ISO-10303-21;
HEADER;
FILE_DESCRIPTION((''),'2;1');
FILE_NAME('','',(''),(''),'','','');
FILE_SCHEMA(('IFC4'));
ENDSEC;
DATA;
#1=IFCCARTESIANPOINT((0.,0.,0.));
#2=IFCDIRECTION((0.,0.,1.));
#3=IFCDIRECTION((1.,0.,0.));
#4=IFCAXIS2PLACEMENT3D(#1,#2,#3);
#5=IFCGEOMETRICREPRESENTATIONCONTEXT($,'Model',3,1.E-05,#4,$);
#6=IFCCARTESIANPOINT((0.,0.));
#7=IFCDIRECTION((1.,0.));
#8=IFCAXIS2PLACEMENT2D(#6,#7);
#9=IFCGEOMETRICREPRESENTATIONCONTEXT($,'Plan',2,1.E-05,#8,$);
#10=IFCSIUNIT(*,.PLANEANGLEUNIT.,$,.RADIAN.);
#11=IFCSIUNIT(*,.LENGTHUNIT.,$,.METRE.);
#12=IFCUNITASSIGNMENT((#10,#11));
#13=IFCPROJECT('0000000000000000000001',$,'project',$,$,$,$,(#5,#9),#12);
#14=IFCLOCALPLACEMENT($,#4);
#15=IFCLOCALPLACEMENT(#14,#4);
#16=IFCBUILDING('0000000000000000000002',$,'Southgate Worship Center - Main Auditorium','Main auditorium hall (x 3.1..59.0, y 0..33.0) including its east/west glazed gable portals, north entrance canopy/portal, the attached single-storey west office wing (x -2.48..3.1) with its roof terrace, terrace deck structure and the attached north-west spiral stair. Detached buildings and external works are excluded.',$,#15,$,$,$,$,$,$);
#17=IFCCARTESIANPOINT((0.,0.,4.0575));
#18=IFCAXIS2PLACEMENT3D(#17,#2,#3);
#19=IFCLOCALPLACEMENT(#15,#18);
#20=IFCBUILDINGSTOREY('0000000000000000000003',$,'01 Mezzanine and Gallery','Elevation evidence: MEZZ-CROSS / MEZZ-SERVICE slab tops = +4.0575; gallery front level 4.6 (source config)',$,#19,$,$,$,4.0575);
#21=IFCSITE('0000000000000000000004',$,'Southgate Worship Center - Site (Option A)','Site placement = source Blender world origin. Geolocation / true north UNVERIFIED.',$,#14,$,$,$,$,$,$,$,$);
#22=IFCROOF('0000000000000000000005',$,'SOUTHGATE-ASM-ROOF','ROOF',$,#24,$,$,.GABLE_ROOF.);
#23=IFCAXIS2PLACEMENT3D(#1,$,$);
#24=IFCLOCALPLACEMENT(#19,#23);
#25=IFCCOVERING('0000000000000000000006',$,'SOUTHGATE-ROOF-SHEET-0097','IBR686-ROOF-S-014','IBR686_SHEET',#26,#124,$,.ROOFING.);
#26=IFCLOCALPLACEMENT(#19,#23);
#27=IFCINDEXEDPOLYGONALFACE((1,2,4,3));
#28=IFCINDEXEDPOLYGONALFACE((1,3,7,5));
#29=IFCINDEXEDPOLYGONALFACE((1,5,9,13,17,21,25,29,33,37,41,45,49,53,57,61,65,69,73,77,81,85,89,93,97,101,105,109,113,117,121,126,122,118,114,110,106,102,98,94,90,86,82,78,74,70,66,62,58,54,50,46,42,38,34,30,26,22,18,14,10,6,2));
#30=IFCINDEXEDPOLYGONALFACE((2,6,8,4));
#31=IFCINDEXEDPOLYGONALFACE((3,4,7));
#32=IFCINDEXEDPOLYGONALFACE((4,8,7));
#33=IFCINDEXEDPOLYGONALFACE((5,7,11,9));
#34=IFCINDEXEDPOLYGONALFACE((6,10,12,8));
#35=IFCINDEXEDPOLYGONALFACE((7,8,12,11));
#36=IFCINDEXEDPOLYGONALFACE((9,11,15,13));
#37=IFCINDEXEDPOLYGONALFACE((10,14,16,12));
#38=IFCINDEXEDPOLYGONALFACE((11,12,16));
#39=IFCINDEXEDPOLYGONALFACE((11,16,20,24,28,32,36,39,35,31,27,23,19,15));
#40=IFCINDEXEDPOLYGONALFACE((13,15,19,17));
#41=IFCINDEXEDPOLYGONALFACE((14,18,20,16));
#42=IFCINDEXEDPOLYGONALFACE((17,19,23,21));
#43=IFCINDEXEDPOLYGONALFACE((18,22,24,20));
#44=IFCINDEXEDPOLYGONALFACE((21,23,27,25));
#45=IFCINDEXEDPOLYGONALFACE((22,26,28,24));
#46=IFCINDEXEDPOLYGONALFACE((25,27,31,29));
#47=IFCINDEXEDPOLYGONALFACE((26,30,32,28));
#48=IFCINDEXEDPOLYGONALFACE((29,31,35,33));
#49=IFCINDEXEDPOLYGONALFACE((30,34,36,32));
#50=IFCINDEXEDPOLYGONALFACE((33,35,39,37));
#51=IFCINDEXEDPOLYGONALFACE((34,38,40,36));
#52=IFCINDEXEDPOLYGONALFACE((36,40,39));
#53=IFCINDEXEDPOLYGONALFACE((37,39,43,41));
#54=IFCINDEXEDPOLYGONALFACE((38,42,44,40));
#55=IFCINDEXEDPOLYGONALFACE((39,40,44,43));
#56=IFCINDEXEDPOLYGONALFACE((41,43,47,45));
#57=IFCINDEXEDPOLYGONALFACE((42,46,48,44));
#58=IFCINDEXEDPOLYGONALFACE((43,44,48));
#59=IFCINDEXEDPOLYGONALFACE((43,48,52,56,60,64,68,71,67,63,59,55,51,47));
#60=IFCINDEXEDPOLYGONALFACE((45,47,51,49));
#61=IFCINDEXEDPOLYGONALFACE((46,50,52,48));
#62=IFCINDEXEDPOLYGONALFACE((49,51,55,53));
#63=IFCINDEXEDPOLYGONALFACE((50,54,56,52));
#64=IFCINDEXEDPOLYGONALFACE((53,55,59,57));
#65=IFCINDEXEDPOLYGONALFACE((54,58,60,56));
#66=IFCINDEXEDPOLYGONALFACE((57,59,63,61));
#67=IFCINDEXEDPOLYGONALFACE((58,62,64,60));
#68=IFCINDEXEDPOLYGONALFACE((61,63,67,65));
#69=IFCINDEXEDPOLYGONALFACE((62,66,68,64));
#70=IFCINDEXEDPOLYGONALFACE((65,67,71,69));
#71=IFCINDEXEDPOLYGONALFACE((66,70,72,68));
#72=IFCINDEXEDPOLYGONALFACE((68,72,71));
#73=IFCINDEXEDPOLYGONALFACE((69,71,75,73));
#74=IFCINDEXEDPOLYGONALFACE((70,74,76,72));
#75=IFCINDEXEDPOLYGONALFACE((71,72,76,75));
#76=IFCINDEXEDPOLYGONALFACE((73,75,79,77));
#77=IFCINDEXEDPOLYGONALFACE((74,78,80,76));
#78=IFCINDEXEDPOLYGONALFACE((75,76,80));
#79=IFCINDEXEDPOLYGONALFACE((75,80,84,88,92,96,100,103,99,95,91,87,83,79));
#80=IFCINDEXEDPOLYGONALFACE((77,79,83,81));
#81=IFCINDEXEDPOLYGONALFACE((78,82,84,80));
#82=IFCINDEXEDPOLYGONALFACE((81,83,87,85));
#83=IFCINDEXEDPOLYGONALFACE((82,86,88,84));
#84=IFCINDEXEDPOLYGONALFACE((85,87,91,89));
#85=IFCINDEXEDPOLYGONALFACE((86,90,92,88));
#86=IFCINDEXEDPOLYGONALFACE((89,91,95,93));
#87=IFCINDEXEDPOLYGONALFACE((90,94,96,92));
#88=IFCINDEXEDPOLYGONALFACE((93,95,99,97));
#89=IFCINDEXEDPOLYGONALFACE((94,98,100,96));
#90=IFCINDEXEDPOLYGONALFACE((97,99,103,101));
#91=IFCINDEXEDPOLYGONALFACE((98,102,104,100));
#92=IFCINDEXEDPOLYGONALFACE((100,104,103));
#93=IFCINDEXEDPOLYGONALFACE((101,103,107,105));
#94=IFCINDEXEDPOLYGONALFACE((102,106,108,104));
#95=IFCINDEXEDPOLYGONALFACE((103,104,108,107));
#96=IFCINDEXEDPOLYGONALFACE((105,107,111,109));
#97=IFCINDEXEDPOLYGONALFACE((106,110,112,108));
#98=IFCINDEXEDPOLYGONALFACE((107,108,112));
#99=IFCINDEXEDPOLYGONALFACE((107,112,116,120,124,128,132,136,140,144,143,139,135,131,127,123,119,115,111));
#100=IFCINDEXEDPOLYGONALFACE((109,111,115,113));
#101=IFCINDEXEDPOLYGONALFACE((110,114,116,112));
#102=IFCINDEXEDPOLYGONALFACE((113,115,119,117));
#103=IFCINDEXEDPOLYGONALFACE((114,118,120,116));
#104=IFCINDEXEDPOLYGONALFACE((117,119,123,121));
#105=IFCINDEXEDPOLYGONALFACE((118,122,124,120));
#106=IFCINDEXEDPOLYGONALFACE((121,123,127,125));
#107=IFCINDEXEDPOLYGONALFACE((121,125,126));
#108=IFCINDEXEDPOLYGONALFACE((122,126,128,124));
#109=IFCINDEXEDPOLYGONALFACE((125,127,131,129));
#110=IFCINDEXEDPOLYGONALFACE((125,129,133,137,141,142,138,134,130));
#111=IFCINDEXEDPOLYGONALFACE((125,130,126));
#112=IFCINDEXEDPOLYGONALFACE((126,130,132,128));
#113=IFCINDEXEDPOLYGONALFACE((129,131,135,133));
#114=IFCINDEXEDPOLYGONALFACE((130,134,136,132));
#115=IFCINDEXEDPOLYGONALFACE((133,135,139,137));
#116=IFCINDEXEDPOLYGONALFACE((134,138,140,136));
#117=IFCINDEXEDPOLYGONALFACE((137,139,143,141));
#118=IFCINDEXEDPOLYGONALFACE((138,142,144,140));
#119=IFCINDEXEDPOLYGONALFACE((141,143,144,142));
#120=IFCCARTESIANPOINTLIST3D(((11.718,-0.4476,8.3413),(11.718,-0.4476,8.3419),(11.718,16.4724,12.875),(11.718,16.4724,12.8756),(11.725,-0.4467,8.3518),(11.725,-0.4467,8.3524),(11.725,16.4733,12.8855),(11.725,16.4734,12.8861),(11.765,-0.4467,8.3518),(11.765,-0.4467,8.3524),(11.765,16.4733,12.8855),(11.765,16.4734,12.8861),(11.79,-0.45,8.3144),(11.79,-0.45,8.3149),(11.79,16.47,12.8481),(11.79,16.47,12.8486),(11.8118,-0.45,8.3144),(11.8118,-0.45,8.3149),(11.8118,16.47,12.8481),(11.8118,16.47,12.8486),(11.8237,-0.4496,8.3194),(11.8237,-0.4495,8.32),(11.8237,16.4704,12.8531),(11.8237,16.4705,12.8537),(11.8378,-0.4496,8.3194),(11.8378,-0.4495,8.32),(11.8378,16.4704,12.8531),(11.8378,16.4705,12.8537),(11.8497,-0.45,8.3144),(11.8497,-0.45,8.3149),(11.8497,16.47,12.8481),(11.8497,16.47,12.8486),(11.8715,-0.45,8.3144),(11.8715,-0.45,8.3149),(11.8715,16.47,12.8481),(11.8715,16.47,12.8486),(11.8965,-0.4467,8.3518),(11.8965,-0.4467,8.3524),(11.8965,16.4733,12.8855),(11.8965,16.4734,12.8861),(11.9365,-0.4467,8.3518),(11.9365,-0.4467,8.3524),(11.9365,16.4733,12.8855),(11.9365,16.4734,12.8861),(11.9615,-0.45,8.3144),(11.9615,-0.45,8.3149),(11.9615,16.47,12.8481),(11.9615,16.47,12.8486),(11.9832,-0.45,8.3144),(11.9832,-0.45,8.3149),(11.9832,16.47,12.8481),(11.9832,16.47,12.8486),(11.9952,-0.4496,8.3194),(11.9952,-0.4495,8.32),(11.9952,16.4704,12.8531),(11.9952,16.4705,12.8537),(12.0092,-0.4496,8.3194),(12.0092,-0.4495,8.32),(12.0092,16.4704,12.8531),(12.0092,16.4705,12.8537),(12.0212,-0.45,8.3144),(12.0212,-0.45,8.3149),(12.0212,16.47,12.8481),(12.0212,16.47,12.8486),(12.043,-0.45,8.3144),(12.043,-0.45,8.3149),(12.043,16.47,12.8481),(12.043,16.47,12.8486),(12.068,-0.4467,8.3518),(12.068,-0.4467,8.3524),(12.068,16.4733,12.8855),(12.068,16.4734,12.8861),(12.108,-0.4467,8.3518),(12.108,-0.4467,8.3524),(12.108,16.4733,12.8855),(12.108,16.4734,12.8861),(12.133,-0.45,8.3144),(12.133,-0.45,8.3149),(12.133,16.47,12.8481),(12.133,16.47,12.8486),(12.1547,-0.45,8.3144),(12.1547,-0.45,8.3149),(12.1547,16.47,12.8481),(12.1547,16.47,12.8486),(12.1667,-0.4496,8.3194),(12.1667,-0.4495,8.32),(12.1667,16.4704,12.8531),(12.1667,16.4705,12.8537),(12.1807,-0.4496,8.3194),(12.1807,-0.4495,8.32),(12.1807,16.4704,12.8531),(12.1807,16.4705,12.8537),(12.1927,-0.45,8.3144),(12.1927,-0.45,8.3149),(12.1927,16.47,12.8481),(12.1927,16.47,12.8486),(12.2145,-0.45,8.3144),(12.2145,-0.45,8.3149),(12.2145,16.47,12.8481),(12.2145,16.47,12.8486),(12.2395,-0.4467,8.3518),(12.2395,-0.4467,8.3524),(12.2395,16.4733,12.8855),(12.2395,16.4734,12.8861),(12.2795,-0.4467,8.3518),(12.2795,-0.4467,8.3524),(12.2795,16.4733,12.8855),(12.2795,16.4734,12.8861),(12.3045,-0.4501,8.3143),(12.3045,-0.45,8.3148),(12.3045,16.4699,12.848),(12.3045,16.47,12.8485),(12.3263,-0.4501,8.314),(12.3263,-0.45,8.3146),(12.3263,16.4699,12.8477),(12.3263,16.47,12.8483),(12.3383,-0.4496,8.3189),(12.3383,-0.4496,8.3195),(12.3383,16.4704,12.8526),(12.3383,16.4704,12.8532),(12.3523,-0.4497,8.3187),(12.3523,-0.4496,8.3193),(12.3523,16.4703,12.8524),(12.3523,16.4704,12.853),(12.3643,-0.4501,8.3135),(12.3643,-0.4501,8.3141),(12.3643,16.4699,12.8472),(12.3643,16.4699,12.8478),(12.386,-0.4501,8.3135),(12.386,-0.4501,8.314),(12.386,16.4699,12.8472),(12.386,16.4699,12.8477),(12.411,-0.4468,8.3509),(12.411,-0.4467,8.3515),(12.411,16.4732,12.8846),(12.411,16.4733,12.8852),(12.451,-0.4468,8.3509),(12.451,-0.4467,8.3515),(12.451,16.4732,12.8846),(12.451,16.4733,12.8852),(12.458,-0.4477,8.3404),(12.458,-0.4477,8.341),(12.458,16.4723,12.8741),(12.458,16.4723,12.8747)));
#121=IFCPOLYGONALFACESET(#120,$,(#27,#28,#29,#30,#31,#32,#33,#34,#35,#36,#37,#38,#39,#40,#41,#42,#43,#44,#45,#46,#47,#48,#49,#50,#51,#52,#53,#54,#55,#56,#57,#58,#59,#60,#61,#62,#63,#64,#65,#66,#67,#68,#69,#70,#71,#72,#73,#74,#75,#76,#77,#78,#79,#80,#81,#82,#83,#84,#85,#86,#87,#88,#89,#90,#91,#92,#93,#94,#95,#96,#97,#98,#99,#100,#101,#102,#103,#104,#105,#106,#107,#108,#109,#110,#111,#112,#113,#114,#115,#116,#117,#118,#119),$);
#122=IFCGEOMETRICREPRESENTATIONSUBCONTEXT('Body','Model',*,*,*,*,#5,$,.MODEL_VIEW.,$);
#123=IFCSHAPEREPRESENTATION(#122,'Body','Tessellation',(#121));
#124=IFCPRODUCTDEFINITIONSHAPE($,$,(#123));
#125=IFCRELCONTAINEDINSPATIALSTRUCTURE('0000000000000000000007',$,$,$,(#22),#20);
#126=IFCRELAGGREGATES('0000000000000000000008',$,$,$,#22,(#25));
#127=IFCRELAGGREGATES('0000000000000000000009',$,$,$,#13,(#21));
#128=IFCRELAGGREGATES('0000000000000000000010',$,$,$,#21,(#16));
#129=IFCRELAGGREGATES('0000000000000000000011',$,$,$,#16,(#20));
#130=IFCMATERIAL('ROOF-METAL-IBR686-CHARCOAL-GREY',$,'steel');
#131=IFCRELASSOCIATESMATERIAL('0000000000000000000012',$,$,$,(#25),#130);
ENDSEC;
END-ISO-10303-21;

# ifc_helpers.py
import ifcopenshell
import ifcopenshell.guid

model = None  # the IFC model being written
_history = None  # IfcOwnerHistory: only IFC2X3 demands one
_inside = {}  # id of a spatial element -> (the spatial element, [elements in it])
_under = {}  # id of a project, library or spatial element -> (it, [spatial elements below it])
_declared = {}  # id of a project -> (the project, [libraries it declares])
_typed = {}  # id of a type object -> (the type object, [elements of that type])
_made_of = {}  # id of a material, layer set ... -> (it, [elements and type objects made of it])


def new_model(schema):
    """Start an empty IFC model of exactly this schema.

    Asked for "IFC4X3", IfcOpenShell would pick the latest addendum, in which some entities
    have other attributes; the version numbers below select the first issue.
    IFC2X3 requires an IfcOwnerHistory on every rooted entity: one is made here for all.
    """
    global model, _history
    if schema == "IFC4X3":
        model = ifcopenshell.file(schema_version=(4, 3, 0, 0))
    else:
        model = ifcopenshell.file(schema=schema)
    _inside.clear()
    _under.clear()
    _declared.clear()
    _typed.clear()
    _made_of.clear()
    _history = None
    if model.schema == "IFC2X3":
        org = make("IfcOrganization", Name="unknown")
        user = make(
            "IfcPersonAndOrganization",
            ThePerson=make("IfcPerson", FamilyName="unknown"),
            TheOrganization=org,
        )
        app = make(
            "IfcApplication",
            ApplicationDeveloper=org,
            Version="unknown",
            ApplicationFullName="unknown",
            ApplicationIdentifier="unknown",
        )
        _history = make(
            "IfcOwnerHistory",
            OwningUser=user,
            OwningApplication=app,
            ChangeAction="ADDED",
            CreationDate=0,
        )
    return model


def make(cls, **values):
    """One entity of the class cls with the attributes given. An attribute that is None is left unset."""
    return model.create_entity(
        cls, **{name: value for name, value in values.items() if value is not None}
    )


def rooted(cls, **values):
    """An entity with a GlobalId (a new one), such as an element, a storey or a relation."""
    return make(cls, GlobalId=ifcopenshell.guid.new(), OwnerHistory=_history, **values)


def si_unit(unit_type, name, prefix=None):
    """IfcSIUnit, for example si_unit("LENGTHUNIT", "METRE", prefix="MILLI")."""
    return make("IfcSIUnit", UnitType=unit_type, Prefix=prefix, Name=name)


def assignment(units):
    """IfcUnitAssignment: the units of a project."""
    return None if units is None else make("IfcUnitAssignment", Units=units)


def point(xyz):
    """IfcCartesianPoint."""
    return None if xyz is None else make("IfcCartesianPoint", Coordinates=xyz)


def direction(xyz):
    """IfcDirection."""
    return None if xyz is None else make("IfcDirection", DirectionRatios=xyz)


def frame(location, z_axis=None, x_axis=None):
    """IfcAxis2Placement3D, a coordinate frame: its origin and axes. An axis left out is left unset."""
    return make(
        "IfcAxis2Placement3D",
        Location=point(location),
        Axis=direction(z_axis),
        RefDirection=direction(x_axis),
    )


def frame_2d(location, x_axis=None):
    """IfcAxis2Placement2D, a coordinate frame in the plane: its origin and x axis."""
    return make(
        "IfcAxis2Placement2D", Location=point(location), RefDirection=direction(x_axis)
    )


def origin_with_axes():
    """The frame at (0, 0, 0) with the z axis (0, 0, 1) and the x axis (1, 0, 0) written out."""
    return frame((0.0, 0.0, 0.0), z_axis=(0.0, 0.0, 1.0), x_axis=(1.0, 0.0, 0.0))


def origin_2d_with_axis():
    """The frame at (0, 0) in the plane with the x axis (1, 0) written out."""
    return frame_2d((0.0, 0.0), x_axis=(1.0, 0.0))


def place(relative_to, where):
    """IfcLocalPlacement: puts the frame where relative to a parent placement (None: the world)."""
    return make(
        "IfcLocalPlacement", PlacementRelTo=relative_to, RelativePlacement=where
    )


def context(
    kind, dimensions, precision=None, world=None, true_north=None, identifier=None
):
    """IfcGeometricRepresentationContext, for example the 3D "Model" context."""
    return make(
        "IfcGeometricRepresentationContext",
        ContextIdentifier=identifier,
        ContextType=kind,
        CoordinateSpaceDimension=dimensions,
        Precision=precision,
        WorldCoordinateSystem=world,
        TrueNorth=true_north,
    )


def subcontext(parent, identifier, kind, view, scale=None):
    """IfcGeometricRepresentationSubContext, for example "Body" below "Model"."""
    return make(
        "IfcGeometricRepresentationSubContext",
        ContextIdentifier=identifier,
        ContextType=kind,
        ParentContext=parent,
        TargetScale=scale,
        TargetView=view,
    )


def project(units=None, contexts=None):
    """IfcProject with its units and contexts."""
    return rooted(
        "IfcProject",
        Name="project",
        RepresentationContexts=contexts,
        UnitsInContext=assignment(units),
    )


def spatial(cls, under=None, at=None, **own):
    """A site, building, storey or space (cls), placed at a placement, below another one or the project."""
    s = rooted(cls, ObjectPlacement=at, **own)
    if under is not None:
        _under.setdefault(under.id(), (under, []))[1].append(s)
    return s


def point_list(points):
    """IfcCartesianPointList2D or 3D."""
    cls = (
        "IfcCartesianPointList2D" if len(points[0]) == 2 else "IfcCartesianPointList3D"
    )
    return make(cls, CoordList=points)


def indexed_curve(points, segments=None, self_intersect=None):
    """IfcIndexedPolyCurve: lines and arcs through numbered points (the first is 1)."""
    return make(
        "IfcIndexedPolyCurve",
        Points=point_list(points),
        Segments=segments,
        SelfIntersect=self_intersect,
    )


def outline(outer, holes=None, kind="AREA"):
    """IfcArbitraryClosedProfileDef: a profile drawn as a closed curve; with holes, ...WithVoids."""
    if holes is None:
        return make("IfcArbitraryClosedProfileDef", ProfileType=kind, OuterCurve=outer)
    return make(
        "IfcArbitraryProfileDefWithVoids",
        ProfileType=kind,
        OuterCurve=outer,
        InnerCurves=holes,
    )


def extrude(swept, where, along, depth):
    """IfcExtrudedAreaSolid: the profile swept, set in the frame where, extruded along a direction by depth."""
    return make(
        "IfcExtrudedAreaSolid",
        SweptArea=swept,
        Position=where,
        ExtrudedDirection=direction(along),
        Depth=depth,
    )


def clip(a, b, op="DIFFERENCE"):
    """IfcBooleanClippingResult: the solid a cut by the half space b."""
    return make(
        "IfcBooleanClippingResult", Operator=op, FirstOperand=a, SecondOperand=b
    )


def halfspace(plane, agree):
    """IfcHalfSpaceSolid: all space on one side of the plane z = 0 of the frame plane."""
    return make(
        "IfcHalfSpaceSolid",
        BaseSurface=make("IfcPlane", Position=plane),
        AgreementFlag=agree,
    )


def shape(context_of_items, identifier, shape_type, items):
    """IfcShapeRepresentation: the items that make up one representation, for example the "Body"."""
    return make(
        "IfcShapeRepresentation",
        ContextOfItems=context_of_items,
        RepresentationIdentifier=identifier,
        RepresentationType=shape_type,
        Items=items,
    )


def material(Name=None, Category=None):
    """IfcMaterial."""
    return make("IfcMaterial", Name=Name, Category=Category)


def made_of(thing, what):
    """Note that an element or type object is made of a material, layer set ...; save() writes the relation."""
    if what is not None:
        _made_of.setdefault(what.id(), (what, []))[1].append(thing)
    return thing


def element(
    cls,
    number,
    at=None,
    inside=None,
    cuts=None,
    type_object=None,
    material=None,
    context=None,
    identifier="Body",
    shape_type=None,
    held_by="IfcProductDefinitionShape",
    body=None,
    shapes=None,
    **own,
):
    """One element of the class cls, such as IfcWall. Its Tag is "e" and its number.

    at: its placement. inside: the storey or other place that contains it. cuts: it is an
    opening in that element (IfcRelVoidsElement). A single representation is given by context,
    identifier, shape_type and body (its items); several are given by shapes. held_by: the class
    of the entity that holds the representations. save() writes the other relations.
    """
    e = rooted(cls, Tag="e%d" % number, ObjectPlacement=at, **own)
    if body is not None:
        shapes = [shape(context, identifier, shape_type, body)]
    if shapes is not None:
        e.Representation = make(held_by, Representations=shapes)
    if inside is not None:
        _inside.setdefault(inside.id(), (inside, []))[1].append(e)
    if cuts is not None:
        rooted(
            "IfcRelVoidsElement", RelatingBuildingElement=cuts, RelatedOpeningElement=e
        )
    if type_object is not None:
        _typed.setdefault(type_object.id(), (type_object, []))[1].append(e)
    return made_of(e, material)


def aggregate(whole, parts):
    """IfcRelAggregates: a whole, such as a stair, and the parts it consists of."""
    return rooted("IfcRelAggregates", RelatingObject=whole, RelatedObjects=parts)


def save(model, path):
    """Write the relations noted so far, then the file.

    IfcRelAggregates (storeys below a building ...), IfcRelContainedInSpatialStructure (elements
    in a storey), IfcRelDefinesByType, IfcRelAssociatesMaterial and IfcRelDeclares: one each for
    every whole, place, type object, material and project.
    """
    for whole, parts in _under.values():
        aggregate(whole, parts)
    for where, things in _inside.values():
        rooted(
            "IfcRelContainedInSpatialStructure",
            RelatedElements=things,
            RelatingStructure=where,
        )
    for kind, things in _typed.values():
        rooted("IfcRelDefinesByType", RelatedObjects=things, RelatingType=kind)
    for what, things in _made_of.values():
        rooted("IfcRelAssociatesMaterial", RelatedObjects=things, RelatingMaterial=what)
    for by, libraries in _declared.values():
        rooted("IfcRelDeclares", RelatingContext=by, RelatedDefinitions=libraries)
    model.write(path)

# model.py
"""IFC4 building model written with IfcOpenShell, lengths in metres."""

from ifc_helpers import new_model, si_unit, frame, origin_with_axes, origin_2d_with_axis, place, context, subcontext, project, spatial, indexed_curve, outline, extrude, clip, halfspace, material, element, aggregate, save


model = new_model("IFC4")

# Units and contexts
model_context = context("Model", 3, precision=1e-05, world=origin_with_axes())
plan_context = context("Plan", 2, precision=1e-05, world=origin_2d_with_axis())
body_context = subcontext(model_context, "Body", "Model", "MODEL_VIEW")
ifc_project = project(units=[si_unit("PLANEANGLEUNIT", "RADIAN"), si_unit("LENGTHUNIT", "METRE")], contexts=[model_context, plan_context])

# Site, building, storey
site_placement = place(None, origin_with_axes())
site = spatial("IfcSite", under=ifc_project, at=site_placement, Name="Southgate Worship Center - Site (Option A)", Description="Site placement = source Blender world origin. Geolocation / true north UNVERIFIED.")
building_placement = place(site_placement, origin_with_axes())
building = spatial("IfcBuilding", under=site, at=building_placement, Name="Southgate Worship Center - Main Auditorium", Description="Main auditorium hall (x 3.1..59.0, y 0..33.0) including its east/west glazed gable portals, north entrance canopy/portal, the attached single-storey west office wing (x -2.48..3.1) with its roof terrace, terrace deck structure and the attached north-west spiral stair. Detached buildings and external works are excluded.")
storey_placement = place(building_placement, frame((0.0, 0.0, 4.0575), z_axis=(0.0, 0.0, 1.0), x_axis=(1.0, 0.0, 0.0)))
storey = spatial("IfcBuildingStorey", under=building, at=storey_placement, Name="01 Mezzanine and Gallery", Description="Elevation evidence: MEZZ-CROSS / MEZZ-SERVICE slab tops = +4.0575; gallery front level 4.6 (source config)", Elevation=4.0575)

# Roof, covering
roof_placement = place(storey_placement, origin_with_axes())
roof = element("IfcRoof", 1, at=roof_placement, inside=storey, Name="SOUTHGATE-ASM-ROOF", Description="ROOF", PredefinedType="GABLE_ROOF")
ifc_material_1 = material(Name="ROOF-METAL-IBR686-CHARCOAL-GREY", Category="steel")
covering_1_placement = place(roof_placement, frame((11.718, -0.4501, 8.3135), z_axis=(0.0, 0.0, 1.0), x_axis=(1.0, 0.0, 0.0)))
covering_1 = element("IfcCovering", 2, at=covering_1_placement, material=ifc_material_1, Name="SOUTHGATE-ROOF-SHEET-0097", Description="IBR686-ROOF-S-014", ObjectType="IBR686_SHEET", PredefinedType="ROOFING", context=body_context, shape_type="Clipping", body=[
    clip(clip(extrude(outline(indexed_curve([(0.0, 0.0), (0.025, 0.0353), (0.065, 0.0353), (0.072, 0.0254), (0.072, 0.0259), (0.065, 0.0358), (0.025, 0.0358), (0.0, 0.0005), (-0.0218, 0.0005), (-0.0337, 0.0053), (-0.0478, 0.0053), (-0.0597, 0.0005), (-0.0815, 0.0005), (-0.1065, 0.0358), (-0.1465, 0.0358), (-0.1715, 0.0005), (-0.1932, 0.0005), (-0.2052, 0.0053), (-0.2192, 0.0053), (-0.2312, 0.0005), (-0.253, 0.0005), (-0.278, 0.0358), (-0.318, 0.0358), (-0.343, 0.0005), (-0.3647, 0.0005), (-0.3767, 0.0053), (-0.3907, 0.0053), (-0.4028, 0.0005), (-0.4245, 0.0005), (-0.4495, 0.0358), (-0.4895, 0.0358), (-0.5145, 0.0004), (-0.5363, 0.0002), (-0.5483, 0.0048), (-0.5623, 0.0046), (-0.5743, -0.0003), (-0.596, -0.0004), (-0.621, 0.0349), (-0.661, 0.0349), (-0.668, 0.0251), (-0.668, 0.0246), (-0.661, 0.0344), (-0.621, 0.0344), (-0.596, -0.0009), (-0.5743, -0.0008), (-0.5623, 0.0041), (-0.5483, 0.0043), (-0.5363, -0.0003), (-0.5145, -0.0001), (-0.4895, 0.0353), (-0.4495, 0.0353), (-0.4245, 0.0), (-0.4028, 0.0), (-0.3907, 0.0048), (-0.3767, 0.0048), (-0.3647, 0.0), (-0.343, 0.0), (-0.318, 0.0353), (-0.278, 0.0353), (-0.253, 0.0), (-0.2312, 0.0), (-0.2192, 0.0048), (-0.2052, 0.0048), (-0.1932, 0.0), (-0.1715, 0.0), (-0.1465, 0.0353), (-0.1065, 0.0353), (-0.0815, 0.0), (-0.0597, 0.0), (-0.0478, 0.0048), (-0.0337, 0.0048), (-0.0218, 0.0), (0.0, 0.0)], self_intersect=False)), frame((0.072, -0.0003, 0.0008), z_axis=(0.0, 0.965926, 0.258819), x_axis=(-1.0, 0.0, 0.0)), (0.0, 0.0, 1.0), 17.5303), halfspace(frame((0.37, 0.0012, 0.014), z_axis=(0.0, -0.996022, 0.089113), x_axis=(1.0, 0.0, 0.0)), False)), halfspace(frame((0.37, 16.9212, 4.5477), z_axis=(0.0, 0.996021, -0.089119), x_axis=(-1.0, 0.0, 0.0)), False)),
])
aggregate(roof, [covering_1])

save(model, "model.ifc")
